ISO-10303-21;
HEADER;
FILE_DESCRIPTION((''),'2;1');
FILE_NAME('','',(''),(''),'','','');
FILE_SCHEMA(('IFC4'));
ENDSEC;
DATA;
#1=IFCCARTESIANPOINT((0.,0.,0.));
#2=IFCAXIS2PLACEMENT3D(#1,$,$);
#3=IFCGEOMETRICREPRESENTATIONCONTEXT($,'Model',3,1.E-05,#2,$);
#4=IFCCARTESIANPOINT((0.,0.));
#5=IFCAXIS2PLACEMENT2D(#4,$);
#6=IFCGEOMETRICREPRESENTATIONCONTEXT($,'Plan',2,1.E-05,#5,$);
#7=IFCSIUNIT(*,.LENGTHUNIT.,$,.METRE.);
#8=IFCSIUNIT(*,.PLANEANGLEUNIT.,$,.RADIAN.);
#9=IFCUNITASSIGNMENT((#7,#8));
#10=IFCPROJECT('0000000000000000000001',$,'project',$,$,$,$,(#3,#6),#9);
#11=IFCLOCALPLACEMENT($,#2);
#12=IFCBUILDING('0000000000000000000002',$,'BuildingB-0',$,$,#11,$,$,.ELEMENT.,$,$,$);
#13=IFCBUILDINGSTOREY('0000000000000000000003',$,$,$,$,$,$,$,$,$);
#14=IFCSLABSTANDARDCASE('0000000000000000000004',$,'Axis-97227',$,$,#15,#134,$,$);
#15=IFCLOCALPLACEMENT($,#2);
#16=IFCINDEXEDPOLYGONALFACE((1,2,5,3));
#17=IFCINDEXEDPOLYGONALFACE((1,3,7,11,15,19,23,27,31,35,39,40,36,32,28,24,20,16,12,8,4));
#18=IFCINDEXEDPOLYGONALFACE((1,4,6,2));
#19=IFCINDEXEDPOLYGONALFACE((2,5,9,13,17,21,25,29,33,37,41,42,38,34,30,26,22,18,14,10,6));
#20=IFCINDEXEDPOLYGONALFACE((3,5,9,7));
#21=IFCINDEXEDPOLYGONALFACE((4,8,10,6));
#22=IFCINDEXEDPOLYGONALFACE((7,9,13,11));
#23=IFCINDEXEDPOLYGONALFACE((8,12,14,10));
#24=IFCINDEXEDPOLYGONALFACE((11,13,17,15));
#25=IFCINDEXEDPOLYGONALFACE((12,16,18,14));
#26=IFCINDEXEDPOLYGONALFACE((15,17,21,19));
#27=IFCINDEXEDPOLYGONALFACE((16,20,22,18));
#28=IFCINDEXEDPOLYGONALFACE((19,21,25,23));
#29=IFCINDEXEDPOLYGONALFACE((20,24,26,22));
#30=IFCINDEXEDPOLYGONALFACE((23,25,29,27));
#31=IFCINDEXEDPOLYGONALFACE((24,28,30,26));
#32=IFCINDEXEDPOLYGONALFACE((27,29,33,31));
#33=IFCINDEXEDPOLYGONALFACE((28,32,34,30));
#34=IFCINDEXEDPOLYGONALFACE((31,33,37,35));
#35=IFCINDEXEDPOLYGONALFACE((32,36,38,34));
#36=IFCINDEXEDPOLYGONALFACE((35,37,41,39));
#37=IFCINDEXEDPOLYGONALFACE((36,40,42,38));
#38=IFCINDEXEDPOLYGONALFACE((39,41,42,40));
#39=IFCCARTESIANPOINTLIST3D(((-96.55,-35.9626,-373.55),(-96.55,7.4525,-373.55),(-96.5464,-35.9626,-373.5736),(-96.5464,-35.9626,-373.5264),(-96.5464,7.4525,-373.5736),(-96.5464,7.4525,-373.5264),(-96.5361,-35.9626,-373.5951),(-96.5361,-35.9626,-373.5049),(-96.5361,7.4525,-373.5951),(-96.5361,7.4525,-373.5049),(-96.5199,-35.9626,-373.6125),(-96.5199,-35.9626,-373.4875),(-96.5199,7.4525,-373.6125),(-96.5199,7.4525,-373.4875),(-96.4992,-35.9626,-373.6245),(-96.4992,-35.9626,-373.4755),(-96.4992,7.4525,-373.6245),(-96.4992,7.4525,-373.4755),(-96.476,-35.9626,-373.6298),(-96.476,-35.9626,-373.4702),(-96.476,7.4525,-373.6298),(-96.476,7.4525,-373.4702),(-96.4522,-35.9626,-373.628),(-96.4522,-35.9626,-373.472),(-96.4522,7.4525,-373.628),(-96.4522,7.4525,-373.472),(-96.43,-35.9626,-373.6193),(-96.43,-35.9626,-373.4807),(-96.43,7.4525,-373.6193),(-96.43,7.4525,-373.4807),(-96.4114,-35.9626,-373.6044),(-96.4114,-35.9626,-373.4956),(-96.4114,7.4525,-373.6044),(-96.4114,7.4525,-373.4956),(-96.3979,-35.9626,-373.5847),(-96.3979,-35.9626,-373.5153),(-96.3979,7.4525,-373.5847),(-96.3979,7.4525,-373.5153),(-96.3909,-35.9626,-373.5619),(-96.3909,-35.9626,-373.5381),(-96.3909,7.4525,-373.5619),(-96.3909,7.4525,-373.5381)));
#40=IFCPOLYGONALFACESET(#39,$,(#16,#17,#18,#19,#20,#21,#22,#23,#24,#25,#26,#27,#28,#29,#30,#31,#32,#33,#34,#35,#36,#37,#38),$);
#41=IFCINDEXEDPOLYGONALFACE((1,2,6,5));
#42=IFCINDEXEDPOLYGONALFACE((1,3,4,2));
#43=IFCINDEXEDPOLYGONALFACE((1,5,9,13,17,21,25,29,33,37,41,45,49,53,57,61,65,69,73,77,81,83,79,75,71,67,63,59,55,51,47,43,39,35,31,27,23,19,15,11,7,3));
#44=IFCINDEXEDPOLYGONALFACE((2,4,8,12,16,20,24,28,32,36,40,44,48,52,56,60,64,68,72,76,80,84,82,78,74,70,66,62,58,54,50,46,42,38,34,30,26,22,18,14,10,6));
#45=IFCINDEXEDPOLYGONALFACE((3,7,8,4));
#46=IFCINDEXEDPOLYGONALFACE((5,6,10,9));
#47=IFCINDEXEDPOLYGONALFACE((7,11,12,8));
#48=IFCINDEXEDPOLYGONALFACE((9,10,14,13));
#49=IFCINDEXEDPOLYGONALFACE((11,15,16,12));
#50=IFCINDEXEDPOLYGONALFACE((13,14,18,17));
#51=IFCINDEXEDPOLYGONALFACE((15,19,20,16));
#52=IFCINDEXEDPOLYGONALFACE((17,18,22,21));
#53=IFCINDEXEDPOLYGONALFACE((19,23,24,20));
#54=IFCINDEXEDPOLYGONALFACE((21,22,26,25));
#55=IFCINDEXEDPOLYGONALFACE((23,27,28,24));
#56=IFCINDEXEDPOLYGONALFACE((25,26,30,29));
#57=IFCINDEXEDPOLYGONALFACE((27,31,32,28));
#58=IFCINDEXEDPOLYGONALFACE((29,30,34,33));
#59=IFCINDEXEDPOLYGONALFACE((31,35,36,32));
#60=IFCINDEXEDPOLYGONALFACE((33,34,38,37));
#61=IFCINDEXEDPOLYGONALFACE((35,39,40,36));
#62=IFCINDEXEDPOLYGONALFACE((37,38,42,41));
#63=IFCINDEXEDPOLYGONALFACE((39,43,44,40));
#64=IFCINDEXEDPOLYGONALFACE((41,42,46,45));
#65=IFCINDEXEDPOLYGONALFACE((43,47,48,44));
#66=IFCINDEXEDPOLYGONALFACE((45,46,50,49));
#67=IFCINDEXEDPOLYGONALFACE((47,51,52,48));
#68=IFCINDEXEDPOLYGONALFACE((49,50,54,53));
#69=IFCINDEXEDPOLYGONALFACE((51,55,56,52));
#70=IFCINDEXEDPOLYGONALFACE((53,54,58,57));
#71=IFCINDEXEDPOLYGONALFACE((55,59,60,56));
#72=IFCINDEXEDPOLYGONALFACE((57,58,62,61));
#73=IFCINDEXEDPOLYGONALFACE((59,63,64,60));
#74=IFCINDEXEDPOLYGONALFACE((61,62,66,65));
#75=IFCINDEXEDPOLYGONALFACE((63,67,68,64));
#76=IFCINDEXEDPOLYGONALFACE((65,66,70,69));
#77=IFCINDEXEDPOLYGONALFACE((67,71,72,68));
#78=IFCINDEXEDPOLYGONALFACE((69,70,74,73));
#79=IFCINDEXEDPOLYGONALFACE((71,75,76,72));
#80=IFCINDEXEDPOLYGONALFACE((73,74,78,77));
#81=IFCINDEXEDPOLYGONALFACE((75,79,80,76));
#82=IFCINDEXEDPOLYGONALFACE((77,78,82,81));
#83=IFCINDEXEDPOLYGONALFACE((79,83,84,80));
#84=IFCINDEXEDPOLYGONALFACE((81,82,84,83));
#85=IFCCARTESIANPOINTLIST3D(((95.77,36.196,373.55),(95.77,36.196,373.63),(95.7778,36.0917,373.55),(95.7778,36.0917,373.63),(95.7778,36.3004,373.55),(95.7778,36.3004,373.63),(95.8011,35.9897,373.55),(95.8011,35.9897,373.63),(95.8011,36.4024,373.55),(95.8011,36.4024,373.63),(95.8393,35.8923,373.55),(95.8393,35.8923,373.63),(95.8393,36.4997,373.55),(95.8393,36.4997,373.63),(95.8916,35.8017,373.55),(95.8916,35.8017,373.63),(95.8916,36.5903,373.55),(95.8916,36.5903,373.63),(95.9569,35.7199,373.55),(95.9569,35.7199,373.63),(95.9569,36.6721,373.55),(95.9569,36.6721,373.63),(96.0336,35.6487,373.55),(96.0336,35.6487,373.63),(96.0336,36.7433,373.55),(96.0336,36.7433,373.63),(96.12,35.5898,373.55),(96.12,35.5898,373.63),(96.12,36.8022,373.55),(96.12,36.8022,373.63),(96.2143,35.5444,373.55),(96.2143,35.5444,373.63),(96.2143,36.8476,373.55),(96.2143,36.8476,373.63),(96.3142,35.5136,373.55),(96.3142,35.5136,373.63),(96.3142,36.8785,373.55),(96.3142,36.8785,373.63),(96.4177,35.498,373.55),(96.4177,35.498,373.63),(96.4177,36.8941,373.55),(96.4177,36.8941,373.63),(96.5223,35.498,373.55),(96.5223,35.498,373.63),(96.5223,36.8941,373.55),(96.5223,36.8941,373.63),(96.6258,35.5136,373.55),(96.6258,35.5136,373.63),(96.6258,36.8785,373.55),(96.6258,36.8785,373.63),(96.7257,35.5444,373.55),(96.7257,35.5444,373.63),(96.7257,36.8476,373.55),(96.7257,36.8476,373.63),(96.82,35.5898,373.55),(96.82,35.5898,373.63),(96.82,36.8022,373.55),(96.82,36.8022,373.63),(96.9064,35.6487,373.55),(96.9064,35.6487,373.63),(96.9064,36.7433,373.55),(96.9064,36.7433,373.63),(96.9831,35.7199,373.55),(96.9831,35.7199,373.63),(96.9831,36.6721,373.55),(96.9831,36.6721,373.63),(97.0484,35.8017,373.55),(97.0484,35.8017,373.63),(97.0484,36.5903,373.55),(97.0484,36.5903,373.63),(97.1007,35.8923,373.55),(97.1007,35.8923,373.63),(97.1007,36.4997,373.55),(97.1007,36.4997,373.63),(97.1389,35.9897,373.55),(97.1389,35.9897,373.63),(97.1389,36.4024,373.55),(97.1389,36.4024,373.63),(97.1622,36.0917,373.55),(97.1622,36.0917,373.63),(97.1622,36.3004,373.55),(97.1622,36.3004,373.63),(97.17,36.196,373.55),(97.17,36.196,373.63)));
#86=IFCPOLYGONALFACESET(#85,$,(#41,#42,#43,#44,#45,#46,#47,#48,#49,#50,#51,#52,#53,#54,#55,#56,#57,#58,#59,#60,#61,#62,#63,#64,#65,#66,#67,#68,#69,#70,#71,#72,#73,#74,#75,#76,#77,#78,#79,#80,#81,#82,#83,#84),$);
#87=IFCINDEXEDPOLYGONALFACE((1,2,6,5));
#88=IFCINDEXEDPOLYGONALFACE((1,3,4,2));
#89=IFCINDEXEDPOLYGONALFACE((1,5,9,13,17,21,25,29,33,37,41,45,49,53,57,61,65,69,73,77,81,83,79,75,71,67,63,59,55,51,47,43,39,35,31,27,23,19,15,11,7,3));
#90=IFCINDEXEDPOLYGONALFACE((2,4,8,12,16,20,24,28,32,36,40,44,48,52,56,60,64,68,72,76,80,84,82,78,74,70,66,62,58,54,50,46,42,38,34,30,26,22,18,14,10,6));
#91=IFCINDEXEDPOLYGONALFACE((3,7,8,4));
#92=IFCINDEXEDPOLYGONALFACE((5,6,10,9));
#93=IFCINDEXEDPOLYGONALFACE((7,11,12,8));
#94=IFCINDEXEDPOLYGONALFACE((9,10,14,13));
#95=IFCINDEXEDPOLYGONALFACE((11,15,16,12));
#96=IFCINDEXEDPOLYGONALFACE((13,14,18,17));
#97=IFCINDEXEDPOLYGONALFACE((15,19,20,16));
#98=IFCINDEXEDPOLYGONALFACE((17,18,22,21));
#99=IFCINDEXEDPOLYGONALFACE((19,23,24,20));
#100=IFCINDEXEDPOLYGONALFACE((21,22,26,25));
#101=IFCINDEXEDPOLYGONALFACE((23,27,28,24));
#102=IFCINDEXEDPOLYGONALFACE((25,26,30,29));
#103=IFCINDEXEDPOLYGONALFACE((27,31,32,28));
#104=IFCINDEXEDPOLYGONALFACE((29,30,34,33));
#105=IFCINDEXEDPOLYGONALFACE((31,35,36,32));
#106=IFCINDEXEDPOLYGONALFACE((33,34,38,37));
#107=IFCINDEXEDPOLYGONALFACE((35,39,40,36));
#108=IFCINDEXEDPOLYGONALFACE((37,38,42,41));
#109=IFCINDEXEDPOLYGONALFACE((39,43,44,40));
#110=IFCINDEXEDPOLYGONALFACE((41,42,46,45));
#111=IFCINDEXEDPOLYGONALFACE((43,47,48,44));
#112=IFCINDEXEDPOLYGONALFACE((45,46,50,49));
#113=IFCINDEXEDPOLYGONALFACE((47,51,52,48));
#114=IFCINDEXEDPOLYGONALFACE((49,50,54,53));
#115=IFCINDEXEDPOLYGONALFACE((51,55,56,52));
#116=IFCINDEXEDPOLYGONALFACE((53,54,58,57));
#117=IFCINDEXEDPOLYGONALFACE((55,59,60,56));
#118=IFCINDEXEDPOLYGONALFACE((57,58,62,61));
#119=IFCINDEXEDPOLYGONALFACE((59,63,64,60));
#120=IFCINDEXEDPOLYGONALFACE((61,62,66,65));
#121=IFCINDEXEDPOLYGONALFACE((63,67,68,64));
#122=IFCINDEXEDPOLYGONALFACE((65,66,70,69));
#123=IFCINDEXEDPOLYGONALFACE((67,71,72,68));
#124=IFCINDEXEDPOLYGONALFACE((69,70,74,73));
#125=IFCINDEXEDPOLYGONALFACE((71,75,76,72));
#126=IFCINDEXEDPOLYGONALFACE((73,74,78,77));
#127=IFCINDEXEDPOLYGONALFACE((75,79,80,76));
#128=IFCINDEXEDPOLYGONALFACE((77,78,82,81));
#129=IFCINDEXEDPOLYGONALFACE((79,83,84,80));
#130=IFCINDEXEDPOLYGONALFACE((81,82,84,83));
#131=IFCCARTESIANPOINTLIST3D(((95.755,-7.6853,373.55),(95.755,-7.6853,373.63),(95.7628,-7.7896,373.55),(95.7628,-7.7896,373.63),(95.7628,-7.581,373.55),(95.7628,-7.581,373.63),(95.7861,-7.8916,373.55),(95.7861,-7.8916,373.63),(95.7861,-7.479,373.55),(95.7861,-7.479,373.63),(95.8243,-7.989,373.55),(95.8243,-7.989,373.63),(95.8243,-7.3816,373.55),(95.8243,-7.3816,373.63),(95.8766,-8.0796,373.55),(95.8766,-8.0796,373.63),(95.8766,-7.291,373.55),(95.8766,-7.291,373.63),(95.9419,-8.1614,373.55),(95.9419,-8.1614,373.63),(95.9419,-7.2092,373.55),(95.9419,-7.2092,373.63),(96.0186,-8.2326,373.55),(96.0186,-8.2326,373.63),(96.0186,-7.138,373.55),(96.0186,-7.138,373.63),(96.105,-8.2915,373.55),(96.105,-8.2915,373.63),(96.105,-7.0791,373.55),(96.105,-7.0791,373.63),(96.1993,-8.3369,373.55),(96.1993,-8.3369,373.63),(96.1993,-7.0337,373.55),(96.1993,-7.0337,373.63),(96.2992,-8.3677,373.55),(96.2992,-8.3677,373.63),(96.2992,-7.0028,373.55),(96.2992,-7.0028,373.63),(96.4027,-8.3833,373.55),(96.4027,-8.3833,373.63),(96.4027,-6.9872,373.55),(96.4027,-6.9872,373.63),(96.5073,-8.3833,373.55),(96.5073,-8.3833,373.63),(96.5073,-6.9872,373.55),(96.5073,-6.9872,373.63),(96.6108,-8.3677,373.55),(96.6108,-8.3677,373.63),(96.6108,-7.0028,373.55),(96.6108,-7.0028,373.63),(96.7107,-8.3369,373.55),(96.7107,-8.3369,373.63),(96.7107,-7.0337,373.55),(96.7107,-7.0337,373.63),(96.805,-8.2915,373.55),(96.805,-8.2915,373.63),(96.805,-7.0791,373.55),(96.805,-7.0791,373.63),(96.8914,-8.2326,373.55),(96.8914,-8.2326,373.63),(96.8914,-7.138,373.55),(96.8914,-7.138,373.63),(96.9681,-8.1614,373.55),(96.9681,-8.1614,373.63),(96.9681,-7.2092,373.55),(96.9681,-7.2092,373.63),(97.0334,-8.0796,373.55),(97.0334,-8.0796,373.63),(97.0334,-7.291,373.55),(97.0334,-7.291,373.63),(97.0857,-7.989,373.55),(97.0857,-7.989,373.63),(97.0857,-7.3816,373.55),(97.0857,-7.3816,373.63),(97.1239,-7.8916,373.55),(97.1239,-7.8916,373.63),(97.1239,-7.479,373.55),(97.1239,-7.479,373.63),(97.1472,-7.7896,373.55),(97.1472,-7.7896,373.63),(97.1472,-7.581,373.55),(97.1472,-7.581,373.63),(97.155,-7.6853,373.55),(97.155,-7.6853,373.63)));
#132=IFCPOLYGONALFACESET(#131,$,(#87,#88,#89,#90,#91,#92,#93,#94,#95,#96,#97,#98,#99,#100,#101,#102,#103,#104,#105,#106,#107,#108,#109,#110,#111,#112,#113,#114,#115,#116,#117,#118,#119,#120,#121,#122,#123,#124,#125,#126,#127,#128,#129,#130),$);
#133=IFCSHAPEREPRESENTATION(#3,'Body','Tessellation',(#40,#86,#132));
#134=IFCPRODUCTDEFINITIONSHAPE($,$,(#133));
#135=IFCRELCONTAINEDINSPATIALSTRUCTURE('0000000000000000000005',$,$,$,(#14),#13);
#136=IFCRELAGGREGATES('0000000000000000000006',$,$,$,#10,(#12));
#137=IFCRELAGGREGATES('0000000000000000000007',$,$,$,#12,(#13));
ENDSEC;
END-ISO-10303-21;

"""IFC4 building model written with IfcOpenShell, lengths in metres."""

from ifc_helpers import new_model, entity, si_unit, frame, origin, origin_2d, place, context, project, spatial, circle, extrude, element, save


model = new_model("IFC4")

# Units and contexts
model_context = context("Model", 3, precision=1e-05, world=origin())
plan_context = context("Plan", 2, precision=1e-05, world=origin_2d())
ifc_project = project(units=[si_unit("LENGTHUNIT", "METRE"), si_unit("PLANEANGLEUNIT", "RADIAN")], contexts=[model_context, plan_context])

# Building, storey
building_placement = place(None, origin())
building = spatial("IfcBuilding", under=ifc_project, at=building_placement, Name="BuildingB-0", CompositionType="ELEMENT")
storey = spatial("IfcBuildingStorey", under=building)

# Slab
element("IfcSlabStandardCase", 1, inside=storey, Name="Axis-97227", context=model_context, shape_type="AdvancedSweptSolid", body=[
    entity("IfcSurfaceCurveSweptAreaSolid", entity("IfcCircleProfileDef", "AREA", None, None, 0.08), None, entity("IfcPolyline", [entity("IfcCartesianPoint", [96.47, 35.9626, 373.55]), entity("IfcCartesianPoint", [96.47, -7.4525, 373.55])]), None, None, entity("IfcPlane", entity("IfcAxis2Placement3D", entity("IfcCartesianPoint", [96.47, 35.9626, 373.55]), entity("IfcDirection", [0.0, 0.0, 1.0]), entity("IfcDirection", [1.0, 0.0, 0.0])))),
    extrude(circle(Radius=0.7), frame((96.47, 36.196, 373.55)), (0.0, 0.0, 1.0), 0.08),
    extrude(circle(Radius=0.7), frame((96.455, -7.6853, 373.55)), (0.0, 0.0, 1.0), 0.08),
])

save(model, "model.ifc")
